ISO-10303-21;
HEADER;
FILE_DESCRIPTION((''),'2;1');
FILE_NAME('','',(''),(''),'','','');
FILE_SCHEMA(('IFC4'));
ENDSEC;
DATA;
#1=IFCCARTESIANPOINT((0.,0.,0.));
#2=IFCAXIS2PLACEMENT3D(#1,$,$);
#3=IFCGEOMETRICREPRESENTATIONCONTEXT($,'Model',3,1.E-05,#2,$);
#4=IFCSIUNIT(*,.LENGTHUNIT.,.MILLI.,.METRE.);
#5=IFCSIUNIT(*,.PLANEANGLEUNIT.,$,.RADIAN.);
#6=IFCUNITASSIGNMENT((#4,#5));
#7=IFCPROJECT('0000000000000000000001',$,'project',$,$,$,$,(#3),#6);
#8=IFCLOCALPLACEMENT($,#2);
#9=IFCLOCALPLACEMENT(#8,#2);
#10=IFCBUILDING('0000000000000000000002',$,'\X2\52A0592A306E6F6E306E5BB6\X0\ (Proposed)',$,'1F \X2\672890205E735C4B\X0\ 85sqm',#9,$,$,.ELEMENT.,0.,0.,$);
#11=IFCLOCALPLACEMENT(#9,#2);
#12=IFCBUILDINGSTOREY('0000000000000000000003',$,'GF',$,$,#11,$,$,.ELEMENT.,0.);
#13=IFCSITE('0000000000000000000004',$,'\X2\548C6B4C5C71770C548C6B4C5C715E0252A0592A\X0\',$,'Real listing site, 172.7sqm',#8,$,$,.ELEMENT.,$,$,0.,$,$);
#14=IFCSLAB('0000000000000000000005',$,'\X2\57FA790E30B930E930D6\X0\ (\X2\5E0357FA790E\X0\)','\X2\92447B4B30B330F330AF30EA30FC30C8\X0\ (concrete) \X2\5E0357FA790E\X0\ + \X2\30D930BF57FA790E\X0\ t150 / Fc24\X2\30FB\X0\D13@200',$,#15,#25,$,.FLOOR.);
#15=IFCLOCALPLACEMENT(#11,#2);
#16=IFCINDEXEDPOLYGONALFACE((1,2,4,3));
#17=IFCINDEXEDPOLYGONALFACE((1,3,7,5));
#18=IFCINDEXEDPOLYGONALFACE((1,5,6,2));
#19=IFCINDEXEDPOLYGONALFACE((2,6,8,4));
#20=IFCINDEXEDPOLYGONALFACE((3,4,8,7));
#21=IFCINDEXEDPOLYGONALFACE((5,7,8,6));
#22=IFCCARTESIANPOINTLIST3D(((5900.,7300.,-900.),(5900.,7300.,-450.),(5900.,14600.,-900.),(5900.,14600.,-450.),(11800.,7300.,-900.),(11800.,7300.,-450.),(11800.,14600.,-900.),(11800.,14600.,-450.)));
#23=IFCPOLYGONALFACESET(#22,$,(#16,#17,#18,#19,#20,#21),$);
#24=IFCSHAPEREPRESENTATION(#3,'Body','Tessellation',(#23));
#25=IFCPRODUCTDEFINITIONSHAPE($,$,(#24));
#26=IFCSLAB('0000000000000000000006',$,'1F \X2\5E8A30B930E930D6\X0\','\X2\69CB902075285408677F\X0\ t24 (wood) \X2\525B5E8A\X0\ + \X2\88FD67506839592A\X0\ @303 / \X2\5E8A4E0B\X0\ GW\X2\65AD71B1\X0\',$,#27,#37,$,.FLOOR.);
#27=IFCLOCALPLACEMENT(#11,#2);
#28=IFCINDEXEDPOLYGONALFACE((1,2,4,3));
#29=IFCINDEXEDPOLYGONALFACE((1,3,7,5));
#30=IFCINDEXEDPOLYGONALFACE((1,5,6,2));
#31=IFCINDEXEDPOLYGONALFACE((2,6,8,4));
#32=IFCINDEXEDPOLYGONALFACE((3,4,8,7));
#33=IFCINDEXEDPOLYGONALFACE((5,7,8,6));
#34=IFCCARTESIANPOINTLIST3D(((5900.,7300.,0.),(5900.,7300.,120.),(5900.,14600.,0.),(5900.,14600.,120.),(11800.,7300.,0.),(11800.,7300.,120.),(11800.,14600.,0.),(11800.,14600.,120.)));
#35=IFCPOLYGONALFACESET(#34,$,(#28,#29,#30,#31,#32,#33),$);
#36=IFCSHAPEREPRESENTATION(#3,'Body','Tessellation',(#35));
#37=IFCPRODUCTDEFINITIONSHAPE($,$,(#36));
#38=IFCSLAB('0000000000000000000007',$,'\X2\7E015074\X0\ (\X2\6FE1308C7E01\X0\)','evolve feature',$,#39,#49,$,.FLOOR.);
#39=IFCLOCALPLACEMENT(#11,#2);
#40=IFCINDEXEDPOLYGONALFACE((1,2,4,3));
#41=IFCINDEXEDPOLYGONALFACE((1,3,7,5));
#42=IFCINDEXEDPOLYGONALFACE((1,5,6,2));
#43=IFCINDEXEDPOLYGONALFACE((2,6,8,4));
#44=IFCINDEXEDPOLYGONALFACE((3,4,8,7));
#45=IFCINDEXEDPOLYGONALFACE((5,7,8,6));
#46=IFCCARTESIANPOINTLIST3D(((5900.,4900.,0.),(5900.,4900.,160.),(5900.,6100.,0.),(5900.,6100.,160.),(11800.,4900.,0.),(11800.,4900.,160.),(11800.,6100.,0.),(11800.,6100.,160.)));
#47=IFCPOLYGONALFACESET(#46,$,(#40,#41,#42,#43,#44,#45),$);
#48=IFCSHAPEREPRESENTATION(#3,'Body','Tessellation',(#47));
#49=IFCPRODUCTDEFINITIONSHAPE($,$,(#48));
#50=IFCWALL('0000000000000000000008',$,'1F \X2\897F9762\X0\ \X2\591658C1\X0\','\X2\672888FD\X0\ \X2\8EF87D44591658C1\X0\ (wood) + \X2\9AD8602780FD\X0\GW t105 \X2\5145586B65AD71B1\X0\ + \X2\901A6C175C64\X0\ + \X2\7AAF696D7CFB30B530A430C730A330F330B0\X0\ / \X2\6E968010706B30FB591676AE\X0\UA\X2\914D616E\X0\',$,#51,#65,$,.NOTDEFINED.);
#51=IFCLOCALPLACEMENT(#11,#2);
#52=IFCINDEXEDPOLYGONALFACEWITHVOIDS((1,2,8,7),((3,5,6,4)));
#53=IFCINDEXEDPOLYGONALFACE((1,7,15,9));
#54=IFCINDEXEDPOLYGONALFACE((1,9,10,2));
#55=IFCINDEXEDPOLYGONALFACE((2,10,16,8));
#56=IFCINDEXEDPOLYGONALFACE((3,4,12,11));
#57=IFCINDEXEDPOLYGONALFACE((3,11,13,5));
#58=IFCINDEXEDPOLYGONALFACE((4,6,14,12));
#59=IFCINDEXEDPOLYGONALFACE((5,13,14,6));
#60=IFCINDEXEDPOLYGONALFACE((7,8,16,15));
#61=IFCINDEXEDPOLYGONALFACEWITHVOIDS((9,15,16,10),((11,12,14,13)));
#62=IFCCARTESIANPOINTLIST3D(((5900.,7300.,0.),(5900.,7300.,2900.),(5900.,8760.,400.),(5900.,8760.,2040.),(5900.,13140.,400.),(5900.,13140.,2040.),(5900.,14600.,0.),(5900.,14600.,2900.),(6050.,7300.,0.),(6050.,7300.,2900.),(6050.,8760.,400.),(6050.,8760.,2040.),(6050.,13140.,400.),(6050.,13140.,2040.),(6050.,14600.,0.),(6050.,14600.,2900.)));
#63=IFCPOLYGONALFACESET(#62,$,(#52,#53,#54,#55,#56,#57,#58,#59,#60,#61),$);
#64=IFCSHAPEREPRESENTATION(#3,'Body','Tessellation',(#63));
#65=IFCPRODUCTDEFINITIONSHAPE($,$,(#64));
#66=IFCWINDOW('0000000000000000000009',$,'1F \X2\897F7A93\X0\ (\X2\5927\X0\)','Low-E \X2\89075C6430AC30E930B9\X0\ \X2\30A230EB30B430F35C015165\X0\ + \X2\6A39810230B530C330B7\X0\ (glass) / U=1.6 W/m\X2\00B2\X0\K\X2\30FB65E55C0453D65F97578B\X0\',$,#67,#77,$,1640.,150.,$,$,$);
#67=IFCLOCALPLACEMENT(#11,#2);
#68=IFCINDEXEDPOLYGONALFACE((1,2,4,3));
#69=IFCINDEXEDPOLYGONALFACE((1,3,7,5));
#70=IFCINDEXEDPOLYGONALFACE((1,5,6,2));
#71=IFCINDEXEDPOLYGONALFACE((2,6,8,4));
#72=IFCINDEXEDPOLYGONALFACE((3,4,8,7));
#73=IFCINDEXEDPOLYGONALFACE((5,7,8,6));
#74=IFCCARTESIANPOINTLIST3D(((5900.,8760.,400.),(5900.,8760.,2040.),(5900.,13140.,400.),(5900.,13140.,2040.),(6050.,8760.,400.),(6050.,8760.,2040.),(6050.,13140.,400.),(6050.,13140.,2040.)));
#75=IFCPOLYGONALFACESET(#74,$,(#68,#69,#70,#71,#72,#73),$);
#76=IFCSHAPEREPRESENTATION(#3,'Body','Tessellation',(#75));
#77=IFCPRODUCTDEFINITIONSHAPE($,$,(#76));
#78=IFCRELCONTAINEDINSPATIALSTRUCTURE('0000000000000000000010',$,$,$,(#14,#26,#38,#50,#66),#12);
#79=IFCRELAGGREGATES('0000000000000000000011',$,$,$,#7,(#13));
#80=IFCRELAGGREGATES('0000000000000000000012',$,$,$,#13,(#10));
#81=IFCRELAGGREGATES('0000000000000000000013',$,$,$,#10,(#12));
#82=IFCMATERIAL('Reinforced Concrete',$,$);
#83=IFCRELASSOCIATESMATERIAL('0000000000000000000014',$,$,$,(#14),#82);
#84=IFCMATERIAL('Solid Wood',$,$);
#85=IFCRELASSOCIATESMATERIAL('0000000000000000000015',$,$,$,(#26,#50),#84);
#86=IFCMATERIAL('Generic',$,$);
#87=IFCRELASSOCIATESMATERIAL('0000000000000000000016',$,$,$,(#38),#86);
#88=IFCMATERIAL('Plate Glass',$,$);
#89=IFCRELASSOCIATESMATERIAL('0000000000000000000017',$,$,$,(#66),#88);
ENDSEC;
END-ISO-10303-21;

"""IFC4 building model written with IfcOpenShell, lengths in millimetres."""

from ifc_helpers import new_model, si_unit, frame, frame_2d, origin, place, context, project, spatial, rectangle, extrude, material, element, fill, save


model = new_model("IFC4")

# Units and contexts
model_context = context("Model", 3, precision=1e-05, world=origin())
ifc_project = project(units=[si_unit("LENGTHUNIT", "METRE", prefix="MILLI"), si_unit("PLANEANGLEUNIT", "RADIAN")], contexts=[model_context])

# Site, building, storey
site_placement = place(None, origin())
site = spatial("IfcSite", under=ifc_project, at=site_placement, Name="和歌山県和歌山市加太", ObjectType="Real listing site, 172.7sqm", CompositionType="ELEMENT", RefElevation=0.0)
building_placement = place(site_placement, origin())
building = spatial("IfcBuilding", under=site, at=building_placement, Name="加太の潮の家 (Proposed)", ObjectType="1F 木造平屋 85sqm", CompositionType="ELEMENT", ElevationOfRefHeight=0.0, ElevationOfTerrain=0.0)
storey_placement = place(building_placement, origin())
storey = spatial("IfcBuildingStorey", under=building, at=storey_placement, Name="GF", CompositionType="ELEMENT", Elevation=0.0)

# Slabs
ifc_material_1 = material(Name="Reinforced Concrete")
slab_1_placement = place(storey_placement, frame((2950.0, 3650.0, -450.0)))
element("IfcSlab", 1, at=slab_1_placement, inside=storey, material=ifc_material_1, Name="基礎スラブ (布基礎)", Description="鉄筋コンクリート (concrete) 布基礎 + ベタ基礎 t150 / Fc24・D13@200", PredefinedType="FLOOR", context=model_context, shape_type="SweptSolid", body=[
    extrude(rectangle(XDim=5900.0, YDim=7300.0, at=frame_2d((2950.0, 3650.0))), frame((2950.0, 3650.0, -450.0)), (0.0, 0.0, 1.0), 450.0),
])
ifc_material_2 = material(Name="Solid Wood")
slab_2_placement = place(storey_placement, frame((2950.0, 3650.0, 0.0)))
element("IfcSlab", 2, at=slab_2_placement, inside=storey, material=ifc_material_2, Name="1F 床スラブ", Description="構造用合板 t24 (wood) 剛床 + 製材根太 @303 / 床下 GW断熱", PredefinedType="FLOOR", context=model_context, shape_type="SweptSolid", body=[
    extrude(rectangle(XDim=5900.0, YDim=7300.0, at=frame_2d((2950.0, 3650.0))), frame((2950.0, 3650.0, 0.0)), (0.0, 0.0, 1.0), 120.0),
])
ifc_material_3 = material(Name="Generic")
slab_3_placement = place(storey_placement, frame((2950.0, 2450.0, 0.0)))
element("IfcSlab", 3, at=slab_3_placement, inside=storey, material=ifc_material_3, Name="縁側 (濡れ縁)", Description="evolve feature", PredefinedType="FLOOR", context=model_context, shape_type="SweptSolid", body=[
    extrude(rectangle(XDim=5900.0, YDim=1200.0, at=frame_2d((2950.0, 600.0))), frame((2950.0, 2450.0, 0.0)), (0.0, 0.0, 1.0), 160.0),
])

# Shared definitions
ifc_material_4 = material(Name="Plate Glass")

# Wall, opening, window
wall_1_placement = place(storey_placement, frame((2950.0, 3650.0, 0.0)))
wall_1 = element("IfcWall", 4, at=wall_1_placement, inside=storey, material=ifc_material_2, Name="1F 西面 外壁", Description="木製 軸組外壁 (wood) + 高性能GW t105 充填断熱 + 通気層 + 窯業系サイディング / 準耐火・外皮UA配慮", PredefinedType="NOTDEFINED", context=model_context, shape_type="SweptSolid", body=[
    extrude(rectangle(XDim=150.0, YDim=7300.0, at=frame_2d((75.0, 3650.0))), frame((2950.0, 3650.0, 0.0)), (0.0, 0.0, 1.0), 2900.0),
])
opening_1_placement = place(storey_placement, frame((2950.0, 4380.0, 200.0)))
opening_1 = element("IfcOpeningElement", 5, at=opening_1_placement, cuts=wall_1, PredefinedType="NOTDEFINED", context=model_context, shape_type="SweptSolid", body=[
    extrude(rectangle(XDim=150.0, YDim=4380.0, at=frame_2d((75.0, 2190.0))), frame((2950.0, 4380.0, 200.0)), (0.0, 0.0, 1.0), 1640.0),
])
window_1_placement = place(storey_placement, frame((2950.0, 4380.0, 200.0)))
window_1 = element("IfcWindow", 6, at=window_1_placement, inside=storey, material=ifc_material_4, Name="1F 西窓 (大)", Description="Low-E 複層ガラス アルゴン封入 + 樹脂サッシ (glass) / U=1.6 W/m²K・日射取得型", OverallHeight=1640.0, OverallWidth=150.0, context=model_context, shape_type="SweptSolid", body=[
    extrude(rectangle(XDim=150.0, YDim=4380.0, at=frame_2d((75.0, 2190.0))), frame((2950.0, 4380.0, 200.0)), (0.0, 0.0, 1.0), 1640.0),
])
fill(opening_1, window_1)

save(model, "model.ifc")
